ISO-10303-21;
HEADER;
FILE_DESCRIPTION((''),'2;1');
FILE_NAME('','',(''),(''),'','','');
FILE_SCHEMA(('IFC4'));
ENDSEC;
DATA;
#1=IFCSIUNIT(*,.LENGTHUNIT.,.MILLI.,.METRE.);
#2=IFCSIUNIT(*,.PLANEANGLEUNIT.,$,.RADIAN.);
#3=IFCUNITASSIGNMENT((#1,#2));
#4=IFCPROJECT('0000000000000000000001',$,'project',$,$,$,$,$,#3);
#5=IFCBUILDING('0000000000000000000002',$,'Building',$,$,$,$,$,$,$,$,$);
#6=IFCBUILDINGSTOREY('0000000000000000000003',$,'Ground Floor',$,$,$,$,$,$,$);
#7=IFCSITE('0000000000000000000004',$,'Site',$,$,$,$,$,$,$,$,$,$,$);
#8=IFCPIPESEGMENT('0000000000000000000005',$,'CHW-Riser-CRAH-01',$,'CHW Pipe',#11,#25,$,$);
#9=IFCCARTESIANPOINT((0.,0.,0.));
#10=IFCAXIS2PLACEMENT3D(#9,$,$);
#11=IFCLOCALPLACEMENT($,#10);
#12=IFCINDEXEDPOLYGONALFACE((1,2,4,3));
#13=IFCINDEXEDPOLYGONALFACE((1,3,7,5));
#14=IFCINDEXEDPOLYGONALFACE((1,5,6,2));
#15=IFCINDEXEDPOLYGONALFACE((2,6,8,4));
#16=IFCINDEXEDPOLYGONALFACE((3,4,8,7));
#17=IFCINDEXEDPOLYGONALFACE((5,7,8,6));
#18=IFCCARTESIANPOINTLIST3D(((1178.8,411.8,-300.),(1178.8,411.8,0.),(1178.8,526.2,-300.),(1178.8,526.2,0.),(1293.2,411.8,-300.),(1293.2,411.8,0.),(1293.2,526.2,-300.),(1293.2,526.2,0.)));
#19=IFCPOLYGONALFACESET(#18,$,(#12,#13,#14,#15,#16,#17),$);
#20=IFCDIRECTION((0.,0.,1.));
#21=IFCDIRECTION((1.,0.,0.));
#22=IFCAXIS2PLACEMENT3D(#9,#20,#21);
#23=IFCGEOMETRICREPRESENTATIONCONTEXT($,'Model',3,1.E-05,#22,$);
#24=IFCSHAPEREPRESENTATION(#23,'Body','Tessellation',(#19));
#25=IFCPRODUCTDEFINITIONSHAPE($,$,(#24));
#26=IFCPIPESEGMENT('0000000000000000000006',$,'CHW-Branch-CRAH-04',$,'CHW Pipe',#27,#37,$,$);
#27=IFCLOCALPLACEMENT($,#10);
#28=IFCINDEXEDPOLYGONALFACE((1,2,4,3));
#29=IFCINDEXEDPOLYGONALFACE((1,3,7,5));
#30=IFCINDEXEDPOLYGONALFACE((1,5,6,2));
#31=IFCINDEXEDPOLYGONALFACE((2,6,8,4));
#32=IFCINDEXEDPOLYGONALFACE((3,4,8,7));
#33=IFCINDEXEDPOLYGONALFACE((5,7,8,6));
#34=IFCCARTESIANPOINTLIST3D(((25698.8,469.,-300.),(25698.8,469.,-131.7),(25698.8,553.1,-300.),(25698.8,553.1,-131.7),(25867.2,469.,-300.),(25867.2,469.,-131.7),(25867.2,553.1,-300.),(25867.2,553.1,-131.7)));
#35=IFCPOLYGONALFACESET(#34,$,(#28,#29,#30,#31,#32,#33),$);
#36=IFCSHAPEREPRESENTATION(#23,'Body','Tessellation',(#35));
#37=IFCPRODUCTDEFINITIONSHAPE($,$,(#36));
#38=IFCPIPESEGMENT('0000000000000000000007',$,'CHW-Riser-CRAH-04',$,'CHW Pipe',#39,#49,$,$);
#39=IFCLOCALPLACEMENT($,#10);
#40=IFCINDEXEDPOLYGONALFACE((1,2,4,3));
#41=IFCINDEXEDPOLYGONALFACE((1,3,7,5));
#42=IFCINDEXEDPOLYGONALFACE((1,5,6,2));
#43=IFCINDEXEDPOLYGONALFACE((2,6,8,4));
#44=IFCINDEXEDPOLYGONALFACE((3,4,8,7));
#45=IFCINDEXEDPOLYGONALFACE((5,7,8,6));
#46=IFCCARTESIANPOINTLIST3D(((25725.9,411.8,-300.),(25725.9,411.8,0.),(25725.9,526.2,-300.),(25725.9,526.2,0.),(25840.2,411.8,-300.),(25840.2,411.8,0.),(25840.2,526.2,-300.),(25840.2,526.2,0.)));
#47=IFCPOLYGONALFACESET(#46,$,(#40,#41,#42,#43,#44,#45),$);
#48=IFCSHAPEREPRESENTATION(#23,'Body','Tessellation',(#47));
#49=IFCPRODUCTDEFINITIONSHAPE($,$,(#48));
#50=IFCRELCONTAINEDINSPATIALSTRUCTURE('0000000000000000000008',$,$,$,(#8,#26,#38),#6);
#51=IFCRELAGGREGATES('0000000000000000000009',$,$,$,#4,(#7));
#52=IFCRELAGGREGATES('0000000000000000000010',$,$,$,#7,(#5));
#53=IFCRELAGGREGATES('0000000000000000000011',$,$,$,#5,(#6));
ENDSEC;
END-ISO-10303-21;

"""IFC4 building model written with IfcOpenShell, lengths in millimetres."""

from ifc_helpers import new_model, si_unit, frame, origin_with_axes, place, context, project, spatial, rectangle, extrude, element, save


model = new_model("IFC4")

# Units and contexts
model_context = context("Model", 3, precision=1e-05, world=origin_with_axes())
ifc_project = project(units=[si_unit("LENGTHUNIT", "METRE", prefix="MILLI"), si_unit("PLANEANGLEUNIT", "RADIAN")])

# Site, building, storey
site = spatial("IfcSite", under=ifc_project, Name="Site")
building = spatial("IfcBuilding", under=site, Name="Building")
storey = spatial("IfcBuildingStorey", under=building, Name="Ground Floor")

# Pipe segments
pipe_segment_1_placement = place(None, origin_with_axes())
element("IfcPipeSegment", 1, at=pipe_segment_1_placement, inside=storey, Name="CHW-Riser-CRAH-01", ObjectType="CHW Pipe", context=model_context, shape_type="SweptSolid", body=[
    extrude(rectangle(XDim=114.3, YDim=114.3), frame((1236.0, 469.0, -300.0), z_axis=(0.0, 0.0, 1.0), x_axis=(1.0, 0.0, 0.0)), (0.0, 0.0, 1.0), 300.0),
])
pipe_segment_2_placement = place(None, origin_with_axes())
element("IfcPipeSegment", 2, at=pipe_segment_2_placement, inside=storey, Name="CHW-Branch-CRAH-04", ObjectType="CHW Pipe", context=model_context, shape_type="SweptSolid", body=[
    extrude(rectangle(XDim=168.3, YDim=84.1), frame((25783.0, 511.1, -300.0), z_axis=(0.0, 0.0, 1.0), x_axis=(1.0, 0.0, 0.0)), (0.0, 0.0, 1.0), 168.3),
])
pipe_segment_3_placement = place(None, origin_with_axes())
element("IfcPipeSegment", 3, at=pipe_segment_3_placement, inside=storey, Name="CHW-Riser-CRAH-04", ObjectType="CHW Pipe", context=model_context, shape_type="SweptSolid", body=[
    extrude(rectangle(XDim=114.3, YDim=114.3), frame((25783.0, 469.0, -300.0), z_axis=(0.0, 0.0, 1.0), x_axis=(1.0, 0.0, 0.0)), (0.0, 0.0, 1.0), 300.0),
])

save(model, "model.ifc")
